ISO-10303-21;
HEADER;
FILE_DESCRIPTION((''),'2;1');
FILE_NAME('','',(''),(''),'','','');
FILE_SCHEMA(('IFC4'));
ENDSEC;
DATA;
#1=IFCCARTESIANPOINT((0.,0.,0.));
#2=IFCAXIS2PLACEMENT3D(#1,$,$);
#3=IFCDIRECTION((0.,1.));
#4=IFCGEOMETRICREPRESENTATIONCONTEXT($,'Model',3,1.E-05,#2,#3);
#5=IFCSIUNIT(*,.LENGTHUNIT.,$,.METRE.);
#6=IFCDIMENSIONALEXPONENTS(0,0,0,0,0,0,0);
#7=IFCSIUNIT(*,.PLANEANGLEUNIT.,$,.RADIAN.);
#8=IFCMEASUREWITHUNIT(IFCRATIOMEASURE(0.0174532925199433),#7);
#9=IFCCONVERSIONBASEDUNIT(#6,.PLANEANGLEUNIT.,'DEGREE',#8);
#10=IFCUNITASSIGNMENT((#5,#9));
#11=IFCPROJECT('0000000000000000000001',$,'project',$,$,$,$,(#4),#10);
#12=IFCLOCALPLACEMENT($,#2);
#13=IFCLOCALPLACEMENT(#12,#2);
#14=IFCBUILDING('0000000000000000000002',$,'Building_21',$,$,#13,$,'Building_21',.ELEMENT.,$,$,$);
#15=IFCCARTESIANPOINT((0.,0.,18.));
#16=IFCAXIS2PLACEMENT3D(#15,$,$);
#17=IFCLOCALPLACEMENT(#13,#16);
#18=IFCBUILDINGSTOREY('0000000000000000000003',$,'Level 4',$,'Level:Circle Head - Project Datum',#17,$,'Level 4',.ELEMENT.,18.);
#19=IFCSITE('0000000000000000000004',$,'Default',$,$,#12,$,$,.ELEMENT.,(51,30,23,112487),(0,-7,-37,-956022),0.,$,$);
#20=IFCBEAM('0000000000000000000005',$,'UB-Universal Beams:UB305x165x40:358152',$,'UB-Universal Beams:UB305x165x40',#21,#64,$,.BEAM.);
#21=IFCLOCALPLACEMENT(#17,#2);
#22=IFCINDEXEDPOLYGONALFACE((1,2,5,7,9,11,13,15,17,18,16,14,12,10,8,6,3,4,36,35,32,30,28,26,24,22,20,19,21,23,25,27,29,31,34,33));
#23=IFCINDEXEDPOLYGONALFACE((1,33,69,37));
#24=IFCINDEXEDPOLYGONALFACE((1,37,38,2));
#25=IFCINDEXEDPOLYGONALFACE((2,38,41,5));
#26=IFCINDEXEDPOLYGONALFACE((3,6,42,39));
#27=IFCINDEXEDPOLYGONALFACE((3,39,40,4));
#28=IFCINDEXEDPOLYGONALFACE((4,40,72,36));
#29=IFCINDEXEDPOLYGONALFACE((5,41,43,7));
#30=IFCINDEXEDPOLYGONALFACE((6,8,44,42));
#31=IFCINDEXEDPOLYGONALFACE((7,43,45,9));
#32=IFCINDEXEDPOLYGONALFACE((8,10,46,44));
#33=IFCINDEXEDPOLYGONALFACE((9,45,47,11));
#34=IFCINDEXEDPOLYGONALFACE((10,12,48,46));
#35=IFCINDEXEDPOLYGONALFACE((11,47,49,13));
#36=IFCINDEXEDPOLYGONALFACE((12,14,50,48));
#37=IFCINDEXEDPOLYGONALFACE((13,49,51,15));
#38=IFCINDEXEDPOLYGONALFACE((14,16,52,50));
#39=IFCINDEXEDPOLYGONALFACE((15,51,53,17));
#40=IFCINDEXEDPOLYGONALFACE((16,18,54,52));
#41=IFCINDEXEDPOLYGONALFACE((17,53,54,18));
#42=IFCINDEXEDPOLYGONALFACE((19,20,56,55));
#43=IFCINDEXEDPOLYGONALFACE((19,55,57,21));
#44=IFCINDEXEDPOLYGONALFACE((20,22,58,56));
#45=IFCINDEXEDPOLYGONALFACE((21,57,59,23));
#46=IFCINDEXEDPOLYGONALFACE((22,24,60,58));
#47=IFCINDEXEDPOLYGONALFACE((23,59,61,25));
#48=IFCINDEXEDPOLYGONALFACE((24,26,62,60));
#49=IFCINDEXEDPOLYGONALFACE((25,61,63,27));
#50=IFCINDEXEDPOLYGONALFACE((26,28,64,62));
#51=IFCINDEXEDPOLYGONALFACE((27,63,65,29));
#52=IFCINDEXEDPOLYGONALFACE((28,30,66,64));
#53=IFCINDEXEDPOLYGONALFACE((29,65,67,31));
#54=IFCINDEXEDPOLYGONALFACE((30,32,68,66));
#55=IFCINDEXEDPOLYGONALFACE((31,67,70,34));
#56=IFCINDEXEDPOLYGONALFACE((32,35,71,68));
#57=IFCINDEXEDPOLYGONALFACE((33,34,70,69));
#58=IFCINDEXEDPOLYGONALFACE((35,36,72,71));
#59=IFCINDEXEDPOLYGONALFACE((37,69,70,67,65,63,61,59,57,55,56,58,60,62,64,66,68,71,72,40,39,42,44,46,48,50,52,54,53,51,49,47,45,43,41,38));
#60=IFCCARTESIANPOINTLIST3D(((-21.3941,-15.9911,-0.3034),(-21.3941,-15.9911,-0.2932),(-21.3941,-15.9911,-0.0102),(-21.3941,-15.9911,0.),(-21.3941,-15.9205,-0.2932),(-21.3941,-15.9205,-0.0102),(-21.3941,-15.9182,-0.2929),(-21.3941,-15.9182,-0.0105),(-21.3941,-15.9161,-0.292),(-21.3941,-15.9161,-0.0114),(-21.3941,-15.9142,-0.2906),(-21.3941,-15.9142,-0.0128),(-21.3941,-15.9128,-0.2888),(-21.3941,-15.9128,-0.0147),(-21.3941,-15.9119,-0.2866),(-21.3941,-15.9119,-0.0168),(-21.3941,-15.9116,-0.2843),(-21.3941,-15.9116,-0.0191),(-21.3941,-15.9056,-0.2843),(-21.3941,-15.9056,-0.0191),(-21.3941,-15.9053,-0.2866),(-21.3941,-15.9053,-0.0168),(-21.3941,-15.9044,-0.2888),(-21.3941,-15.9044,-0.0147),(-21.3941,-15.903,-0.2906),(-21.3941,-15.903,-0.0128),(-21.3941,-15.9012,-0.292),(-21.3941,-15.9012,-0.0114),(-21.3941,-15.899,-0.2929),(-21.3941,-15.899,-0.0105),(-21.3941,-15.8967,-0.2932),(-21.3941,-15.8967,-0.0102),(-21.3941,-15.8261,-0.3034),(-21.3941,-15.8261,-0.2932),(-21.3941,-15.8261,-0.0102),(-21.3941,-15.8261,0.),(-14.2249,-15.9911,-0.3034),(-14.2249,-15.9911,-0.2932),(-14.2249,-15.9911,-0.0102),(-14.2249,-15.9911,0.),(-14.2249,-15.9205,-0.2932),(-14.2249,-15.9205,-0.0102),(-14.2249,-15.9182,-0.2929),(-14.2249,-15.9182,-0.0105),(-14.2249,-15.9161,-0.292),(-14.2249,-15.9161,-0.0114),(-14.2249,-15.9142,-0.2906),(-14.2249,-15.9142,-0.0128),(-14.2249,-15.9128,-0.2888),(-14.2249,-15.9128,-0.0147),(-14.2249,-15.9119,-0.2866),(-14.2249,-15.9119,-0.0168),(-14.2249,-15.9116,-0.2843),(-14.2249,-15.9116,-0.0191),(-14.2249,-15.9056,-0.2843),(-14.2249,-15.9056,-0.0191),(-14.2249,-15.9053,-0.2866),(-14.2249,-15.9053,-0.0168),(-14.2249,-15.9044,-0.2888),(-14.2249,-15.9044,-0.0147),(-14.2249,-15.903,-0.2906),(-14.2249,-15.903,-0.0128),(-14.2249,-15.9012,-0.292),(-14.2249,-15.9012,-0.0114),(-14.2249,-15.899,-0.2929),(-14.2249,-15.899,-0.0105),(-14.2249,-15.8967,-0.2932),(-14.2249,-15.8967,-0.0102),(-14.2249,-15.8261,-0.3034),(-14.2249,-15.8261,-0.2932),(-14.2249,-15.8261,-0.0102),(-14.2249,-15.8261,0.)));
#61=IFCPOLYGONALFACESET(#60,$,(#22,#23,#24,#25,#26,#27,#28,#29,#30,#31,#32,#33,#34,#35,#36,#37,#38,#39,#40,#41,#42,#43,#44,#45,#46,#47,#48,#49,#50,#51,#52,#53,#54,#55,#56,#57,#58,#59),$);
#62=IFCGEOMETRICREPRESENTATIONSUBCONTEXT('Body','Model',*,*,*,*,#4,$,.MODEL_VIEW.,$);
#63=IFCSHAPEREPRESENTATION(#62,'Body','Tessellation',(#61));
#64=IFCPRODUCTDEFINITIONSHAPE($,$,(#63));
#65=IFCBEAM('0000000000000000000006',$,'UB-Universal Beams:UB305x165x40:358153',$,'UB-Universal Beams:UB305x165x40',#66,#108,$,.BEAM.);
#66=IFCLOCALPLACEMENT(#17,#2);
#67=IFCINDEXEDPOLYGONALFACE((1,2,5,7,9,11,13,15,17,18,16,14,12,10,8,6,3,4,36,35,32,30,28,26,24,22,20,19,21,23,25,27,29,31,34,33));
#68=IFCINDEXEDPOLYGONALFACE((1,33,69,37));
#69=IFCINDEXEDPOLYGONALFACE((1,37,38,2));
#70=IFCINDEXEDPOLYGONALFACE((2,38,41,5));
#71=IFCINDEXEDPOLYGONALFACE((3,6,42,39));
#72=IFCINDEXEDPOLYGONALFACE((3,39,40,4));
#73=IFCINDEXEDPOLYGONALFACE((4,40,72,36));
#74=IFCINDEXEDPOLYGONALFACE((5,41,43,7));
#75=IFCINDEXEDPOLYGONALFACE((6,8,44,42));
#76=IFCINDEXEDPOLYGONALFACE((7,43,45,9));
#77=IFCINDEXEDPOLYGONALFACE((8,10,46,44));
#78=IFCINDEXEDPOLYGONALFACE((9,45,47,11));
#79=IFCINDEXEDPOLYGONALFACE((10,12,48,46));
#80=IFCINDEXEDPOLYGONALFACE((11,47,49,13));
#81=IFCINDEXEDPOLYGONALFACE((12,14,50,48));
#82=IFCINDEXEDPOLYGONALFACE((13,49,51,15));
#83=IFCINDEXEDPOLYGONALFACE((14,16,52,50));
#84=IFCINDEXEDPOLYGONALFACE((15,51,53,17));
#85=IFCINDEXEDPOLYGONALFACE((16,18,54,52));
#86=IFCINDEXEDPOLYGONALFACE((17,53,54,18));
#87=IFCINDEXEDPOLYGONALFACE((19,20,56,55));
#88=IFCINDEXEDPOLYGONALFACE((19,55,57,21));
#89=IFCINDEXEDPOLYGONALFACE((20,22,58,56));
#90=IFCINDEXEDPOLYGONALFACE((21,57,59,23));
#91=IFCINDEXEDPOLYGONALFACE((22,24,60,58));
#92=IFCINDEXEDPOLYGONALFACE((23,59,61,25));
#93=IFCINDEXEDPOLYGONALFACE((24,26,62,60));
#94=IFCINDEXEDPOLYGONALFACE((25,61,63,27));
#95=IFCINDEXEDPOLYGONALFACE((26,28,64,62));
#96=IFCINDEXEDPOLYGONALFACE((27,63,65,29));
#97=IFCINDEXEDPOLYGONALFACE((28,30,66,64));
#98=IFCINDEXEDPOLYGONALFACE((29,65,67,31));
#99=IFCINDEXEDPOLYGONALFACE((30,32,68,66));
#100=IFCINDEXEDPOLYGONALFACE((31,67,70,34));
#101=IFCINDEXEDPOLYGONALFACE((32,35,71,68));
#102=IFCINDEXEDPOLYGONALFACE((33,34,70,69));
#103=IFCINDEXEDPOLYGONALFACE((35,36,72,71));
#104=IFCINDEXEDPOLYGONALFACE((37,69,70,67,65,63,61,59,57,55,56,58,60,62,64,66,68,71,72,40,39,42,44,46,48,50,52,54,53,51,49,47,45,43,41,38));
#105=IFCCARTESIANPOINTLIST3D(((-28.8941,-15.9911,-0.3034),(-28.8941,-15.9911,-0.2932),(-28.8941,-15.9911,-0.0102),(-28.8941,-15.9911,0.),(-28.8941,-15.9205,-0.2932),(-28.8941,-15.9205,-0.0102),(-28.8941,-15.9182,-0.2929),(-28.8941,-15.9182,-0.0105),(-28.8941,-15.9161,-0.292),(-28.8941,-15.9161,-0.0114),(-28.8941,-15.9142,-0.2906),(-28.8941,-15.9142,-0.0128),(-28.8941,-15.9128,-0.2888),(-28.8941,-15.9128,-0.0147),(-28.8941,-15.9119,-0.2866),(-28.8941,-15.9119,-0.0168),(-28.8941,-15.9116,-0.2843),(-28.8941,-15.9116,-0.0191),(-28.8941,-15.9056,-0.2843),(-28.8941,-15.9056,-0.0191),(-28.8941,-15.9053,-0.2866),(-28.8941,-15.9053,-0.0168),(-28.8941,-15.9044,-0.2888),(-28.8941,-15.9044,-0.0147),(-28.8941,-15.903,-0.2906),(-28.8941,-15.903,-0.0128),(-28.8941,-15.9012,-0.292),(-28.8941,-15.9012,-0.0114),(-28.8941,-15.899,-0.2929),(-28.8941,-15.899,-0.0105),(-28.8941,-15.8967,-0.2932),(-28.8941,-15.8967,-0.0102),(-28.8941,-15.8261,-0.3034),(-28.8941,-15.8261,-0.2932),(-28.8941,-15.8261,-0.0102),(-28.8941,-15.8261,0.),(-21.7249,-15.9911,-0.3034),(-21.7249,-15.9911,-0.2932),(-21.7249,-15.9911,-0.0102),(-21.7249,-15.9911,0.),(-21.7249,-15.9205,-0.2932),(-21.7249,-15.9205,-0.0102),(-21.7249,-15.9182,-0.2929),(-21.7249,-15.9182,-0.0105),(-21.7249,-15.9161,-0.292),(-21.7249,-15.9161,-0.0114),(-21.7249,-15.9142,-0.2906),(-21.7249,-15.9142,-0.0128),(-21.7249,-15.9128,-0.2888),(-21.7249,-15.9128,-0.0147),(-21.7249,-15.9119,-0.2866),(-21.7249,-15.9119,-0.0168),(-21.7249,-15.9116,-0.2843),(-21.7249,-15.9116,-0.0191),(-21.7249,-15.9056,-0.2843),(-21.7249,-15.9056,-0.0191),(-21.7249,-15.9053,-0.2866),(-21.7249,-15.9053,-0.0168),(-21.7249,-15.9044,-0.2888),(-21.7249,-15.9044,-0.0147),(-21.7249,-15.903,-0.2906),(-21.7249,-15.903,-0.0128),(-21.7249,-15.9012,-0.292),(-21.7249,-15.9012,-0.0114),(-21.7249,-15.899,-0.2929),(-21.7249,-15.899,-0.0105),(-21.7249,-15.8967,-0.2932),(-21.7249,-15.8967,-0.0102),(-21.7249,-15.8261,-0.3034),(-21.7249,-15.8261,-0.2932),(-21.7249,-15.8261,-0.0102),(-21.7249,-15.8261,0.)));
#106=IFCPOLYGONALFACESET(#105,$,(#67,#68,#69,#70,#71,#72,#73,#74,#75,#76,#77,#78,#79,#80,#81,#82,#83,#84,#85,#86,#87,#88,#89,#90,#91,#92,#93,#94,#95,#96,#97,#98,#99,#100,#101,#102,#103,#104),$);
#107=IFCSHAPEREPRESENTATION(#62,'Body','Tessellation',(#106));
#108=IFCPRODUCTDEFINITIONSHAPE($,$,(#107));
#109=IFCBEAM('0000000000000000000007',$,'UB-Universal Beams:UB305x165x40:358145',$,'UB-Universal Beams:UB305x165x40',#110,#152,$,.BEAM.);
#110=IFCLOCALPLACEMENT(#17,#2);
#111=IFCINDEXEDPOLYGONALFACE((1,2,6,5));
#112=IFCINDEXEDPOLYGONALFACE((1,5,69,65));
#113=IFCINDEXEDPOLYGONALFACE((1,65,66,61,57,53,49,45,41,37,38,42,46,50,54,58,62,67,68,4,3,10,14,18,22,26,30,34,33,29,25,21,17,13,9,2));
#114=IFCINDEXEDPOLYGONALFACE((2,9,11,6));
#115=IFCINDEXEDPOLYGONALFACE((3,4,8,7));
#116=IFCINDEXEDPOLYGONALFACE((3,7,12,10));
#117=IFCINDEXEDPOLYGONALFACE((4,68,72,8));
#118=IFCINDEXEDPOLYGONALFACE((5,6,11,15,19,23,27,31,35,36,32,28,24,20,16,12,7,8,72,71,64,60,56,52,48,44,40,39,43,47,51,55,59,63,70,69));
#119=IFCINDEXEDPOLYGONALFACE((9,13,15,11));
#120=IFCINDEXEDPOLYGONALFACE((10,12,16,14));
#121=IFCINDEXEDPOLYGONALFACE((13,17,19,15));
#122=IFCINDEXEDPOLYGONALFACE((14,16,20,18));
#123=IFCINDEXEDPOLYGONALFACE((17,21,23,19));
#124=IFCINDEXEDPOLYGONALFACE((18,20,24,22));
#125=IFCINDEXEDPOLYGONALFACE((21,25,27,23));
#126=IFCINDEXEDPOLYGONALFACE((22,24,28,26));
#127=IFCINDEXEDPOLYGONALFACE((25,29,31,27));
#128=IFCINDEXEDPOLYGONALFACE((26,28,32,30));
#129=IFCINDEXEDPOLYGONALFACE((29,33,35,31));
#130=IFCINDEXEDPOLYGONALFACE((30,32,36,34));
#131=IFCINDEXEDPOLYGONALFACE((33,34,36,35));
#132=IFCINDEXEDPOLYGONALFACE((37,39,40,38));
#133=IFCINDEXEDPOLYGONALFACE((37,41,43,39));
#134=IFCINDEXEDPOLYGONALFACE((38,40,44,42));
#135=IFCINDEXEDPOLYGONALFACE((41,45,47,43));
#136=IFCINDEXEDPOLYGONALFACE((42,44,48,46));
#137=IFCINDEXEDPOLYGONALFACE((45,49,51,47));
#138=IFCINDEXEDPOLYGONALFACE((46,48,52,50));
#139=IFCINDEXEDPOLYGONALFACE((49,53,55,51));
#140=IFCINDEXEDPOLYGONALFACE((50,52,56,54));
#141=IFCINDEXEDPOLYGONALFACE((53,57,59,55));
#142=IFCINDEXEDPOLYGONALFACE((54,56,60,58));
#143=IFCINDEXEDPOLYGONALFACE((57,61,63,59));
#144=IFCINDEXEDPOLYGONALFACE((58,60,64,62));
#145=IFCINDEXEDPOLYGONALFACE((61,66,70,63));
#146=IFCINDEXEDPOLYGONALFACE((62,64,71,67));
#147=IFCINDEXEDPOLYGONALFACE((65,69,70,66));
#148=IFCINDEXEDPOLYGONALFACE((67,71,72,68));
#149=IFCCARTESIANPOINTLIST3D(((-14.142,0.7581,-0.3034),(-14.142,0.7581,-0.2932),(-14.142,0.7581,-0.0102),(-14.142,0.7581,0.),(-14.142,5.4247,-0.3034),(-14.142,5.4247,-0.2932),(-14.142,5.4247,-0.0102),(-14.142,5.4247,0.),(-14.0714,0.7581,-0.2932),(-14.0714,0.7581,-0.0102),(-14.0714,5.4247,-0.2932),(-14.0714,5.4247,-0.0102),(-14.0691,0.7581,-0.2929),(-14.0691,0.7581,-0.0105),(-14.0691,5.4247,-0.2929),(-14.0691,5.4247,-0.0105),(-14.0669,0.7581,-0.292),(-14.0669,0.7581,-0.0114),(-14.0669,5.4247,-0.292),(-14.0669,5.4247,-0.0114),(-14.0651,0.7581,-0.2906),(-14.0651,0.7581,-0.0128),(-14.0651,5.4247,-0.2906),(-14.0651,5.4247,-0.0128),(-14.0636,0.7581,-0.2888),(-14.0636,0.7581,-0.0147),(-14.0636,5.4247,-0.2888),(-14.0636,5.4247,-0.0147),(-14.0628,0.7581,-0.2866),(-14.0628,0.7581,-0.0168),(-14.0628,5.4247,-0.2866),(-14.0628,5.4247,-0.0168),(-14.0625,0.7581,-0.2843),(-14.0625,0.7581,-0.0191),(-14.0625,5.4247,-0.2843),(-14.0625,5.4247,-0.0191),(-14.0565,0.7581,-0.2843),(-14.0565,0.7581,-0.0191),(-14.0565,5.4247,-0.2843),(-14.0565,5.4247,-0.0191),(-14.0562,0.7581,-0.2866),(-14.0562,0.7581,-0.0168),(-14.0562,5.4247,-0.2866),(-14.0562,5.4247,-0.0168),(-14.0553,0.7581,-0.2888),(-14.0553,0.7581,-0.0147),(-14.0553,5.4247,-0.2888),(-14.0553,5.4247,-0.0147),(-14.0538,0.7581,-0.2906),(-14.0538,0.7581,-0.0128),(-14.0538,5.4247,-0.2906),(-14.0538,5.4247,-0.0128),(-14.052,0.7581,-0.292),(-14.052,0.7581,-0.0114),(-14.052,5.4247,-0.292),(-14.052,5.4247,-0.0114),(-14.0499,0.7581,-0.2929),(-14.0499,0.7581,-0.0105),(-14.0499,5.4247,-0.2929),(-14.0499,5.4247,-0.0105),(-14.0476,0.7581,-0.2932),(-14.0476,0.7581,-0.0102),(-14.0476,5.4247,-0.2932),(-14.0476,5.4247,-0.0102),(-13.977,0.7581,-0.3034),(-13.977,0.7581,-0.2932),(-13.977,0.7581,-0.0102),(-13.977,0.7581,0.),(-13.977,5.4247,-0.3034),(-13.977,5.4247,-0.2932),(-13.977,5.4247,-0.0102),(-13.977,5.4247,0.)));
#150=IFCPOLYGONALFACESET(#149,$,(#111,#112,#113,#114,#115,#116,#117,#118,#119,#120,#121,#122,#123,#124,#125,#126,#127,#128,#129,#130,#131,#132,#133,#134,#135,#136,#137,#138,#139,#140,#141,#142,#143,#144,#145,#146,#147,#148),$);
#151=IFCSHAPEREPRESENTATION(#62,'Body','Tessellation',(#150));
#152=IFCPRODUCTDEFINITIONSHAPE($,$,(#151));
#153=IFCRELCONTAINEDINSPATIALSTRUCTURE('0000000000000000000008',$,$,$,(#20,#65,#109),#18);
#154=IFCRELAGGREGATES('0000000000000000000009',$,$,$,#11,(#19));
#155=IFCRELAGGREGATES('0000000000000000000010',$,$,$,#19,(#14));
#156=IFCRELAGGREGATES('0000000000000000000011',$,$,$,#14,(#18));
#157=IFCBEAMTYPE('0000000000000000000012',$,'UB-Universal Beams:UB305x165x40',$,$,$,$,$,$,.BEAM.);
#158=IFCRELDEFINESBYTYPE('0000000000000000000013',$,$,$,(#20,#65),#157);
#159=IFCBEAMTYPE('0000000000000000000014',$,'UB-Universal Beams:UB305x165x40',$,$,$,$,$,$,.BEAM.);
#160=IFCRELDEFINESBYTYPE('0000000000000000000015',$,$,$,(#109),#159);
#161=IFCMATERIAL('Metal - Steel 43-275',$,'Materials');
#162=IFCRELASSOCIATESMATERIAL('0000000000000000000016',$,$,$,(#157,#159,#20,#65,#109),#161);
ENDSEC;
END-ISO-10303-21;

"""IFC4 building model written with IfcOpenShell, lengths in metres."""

from ifc_helpers import new_model, entity, si_unit, converted_unit, direction, frame, frame_2d, origin, place, context, subcontext, project, spatial, polyline, circle_curve, parameter, trimmed, segment, composite_curve, i_section, outline, extrude, source, transform, mapped, material, material_profile, profile_set, profile_usage, type_object, type_shapes, element, save


model = new_model("IFC4")

# Units and contexts
model_context = context("Model", 3, precision=1e-05, world=origin(), true_north=direction((0.0, 1.0)))
body_context = subcontext(model_context, "Body", "Model", "MODEL_VIEW")
ifc_project = project(units=[si_unit("LENGTHUNIT", "METRE"), converted_unit("PLANEANGLEUNIT", "DEGREE", entity("IfcRatioMeasure", 0.0174532925199433), si_unit("PLANEANGLEUNIT", "RADIAN"), dimensions=[0, 0, 0, 0, 0, 0, 0])], contexts=[model_context])

# Site, building, storey
site_placement = place(None, origin())
site = spatial("IfcSite", under=ifc_project, at=site_placement, Name="Default", CompositionType="ELEMENT", RefLatitude=(51, 30, 23, 112487), RefLongitude=(0, -7, -37, -956022), RefElevation=0.0)
building_placement = place(site_placement, origin())
building = spatial("IfcBuilding", under=site, at=building_placement, Name="Building_21", LongName="Building_21", CompositionType="ELEMENT")
storey_placement = place(building_placement, frame((0.0, 0.0, 18.0)))
storey = spatial("IfcBuildingStorey", under=building, at=storey_placement, Name="Level 4", ObjectType="Level:Circle Head - Project Datum", LongName="Level 4", CompositionType="ELEMENT", Elevation=18.0)

# Beams
ifc_material_1 = material(Name="Metal - Steel 43-275", Category="Materials")
ifc_material_profile_1 = material_profile(ifc_material_1, outline(composite_curve([segment(polyline([(0.0119, -0.1415, 0.0), (0.0825, -0.1415, 0.0)]), True, "CONTINUOUS"), segment(polyline([(0.0825, -0.1415, 0.0), (0.0825, -0.1517, 0.0)]), True, "CONTINUOUS"), segment(polyline([(0.0825, -0.1517, 0.0), (-0.0825, -0.1517, 0.0)]), True, "CONTINUOUS"), segment(polyline([(-0.0825, -0.1517, 0.0), (-0.0825, -0.1415, 0.0)]), True, "CONTINUOUS"), segment(polyline([(-0.0825, -0.1415, 0.0), (-0.0119, -0.1415, 0.0)]), True, "CONTINUOUS"), segment(trimmed(circle_curve(frame((-0.0119, -0.1326, 0.0), z_axis=(0.0, 0.0, 1.0), x_axis=(-1.0, 0.0, 0.0)), 0.0089), [parameter(90.0)], [parameter(180.0)], True, "PARAMETER"), True, "CONTINUOUS"), segment(polyline([(-0.003, -0.1326, 0.0), (-0.003, 0.1326, 0.0)]), True, "CONTINUOUS"), segment(trimmed(circle_curve(frame((-0.0119, 0.1326, 0.0), z_axis=(0.0, 0.0, 1.0), x_axis=(-1.0, 0.0, 0.0)), 0.0089), [parameter(180.0)], [parameter(270.0)], True, "PARAMETER"), True, "CONTINUOUS"), segment(polyline([(-0.0119, 0.1415, 0.0), (-0.0825, 0.1415, 0.0)]), True, "CONTINUOUS"), segment(polyline([(-0.0825, 0.1415, 0.0), (-0.0825, 0.1517, 0.0)]), True, "CONTINUOUS"), segment(polyline([(-0.0825, 0.1517, 0.0), (0.0825, 0.1517, 0.0)]), True, "CONTINUOUS"), segment(polyline([(0.0825, 0.1517, 0.0), (0.0825, 0.1415, 0.0)]), True, "CONTINUOUS"), segment(polyline([(0.0825, 0.1415, 0.0), (0.0119, 0.1415, 0.0)]), True, "CONTINUOUS"), segment(trimmed(circle_curve(frame((0.0119, 0.1326, 0.0), z_axis=(0.0, 0.0, 1.0), x_axis=(-1.0, 0.0, 0.0)), 0.0089), [parameter(270.0)], [parameter(0.0)], True, "PARAMETER"), True, "CONTINUOUS"), segment(polyline([(0.003, 0.1326, 0.0), (0.003, -0.1326, 0.0)]), True, "CONTINUOUS"), segment(trimmed(circle_curve(frame((0.0119, -0.1326, 0.0), z_axis=(0.0, 0.0, 1.0), x_axis=(-1.0, 0.0, 0.0)), 0.0089), [parameter(0.0)], [parameter(90.0)], True, "PARAMETER"), True, "CONTINUOUS")], self_intersect=False), kind="CURVE"), Name="UB305x165x40")
ifc_material_profile_2 = material_profile(ifc_material_1, outline(composite_curve([segment(polyline([(-1.3346, 0.0825, -0.1415), (-1.3346, 0.0825, -0.1517)]), True, "CONTINUOUS"), segment(polyline([(-1.3346, 0.0825, -0.1517), (-1.3346, -0.0825, -0.1517)]), True, "CONTINUOUS"), segment(polyline([(-1.3346, -0.0825, -0.1517), (-1.3346, -0.0825, -0.1415)]), True, "CONTINUOUS"), segment(polyline([(-1.3346, -0.0825, -0.1415), (-1.3346, -0.003, -0.1415)]), True, "CONTINUOUS"), segment(polyline([(-1.3346, -0.003, -0.1415), (-1.3346, -0.003, 0.1415)]), True, "CONTINUOUS"), segment(polyline([(-1.3346, -0.003, 0.1415), (-1.3346, -0.0825, 0.1415)]), True, "CONTINUOUS"), segment(polyline([(-1.3346, -0.0825, 0.1415), (-1.3346, -0.0825, 0.1517)]), True, "CONTINUOUS"), segment(polyline([(-1.3346, -0.0825, 0.1517), (-1.3346, 0.0825, 0.1517)]), True, "CONTINUOUS"), segment(polyline([(-1.3346, 0.0825, 0.1517), (-1.3346, 0.0825, 0.1415)]), True, "CONTINUOUS"), segment(polyline([(-1.3346, 0.0825, 0.1415), (-1.3346, 0.003, 0.1415)]), True, "CONTINUOUS"), segment(polyline([(-1.3346, 0.003, 0.1415), (-1.3346, 0.003, -0.1415)]), True, "CONTINUOUS"), segment(polyline([(-1.3346, 0.003, -0.1415), (-1.3346, 0.0825, -0.1415)]), True, "CONTINUOUS")], self_intersect=False), kind="CURVE"), Name="UB305x165x40")
ifc_profile_set = profile_set([ifc_material_profile_1, ifc_material_profile_2], Name="UB305x165x40")
beam_type_1 = type_object("IfcBeamType", Name="UB-Universal Beams:UB305x165x40", PredefinedType="BEAM", material=ifc_profile_set)
shared_shape_1 = source(origin(), body_context, "Body", "SweptSolid", [
    extrude(i_section(OverallWidth=0.165, OverallDepth=0.3034, WebThickness=0.006, FlangeThickness=0.0102, FilletRadius=0.0089, at=frame_2d((0.0, 0.0), x_axis=(0.0, 1.0))), frame((-3.5846, 0.0, 0.0), z_axis=(1.0, 0.0, 0.0), x_axis=(0.0, 0.0, -1.0)), (0.0, 0.0, 1.0), 7.1692),
])
type_shapes(beam_type_1, [shared_shape_1])
ifc_profile_usage_1 = profile_usage(ifc_profile_set, cardinal=8)
beam_1_placement = place(storey_placement, frame((-17.8095, -15.9086, -0.1517)))
element("IfcBeam", 1, at=beam_1_placement, inside=storey, type_object=beam_type_1, material=ifc_profile_usage_1, Name="UB-Universal Beams:UB305x165x40:358152", ObjectType="UB-Universal Beams:UB305x165x40", PredefinedType="BEAM", context=body_context, shape_type="MappedRepresentation", body=[
    mapped(shared_shape_1, transform((0.0, 0.0, 0.0), scale=1.0)),
])
ifc_profile_usage_2 = profile_usage(ifc_profile_set, cardinal=8)
beam_2_placement = place(storey_placement, frame((-25.3095, -15.9086, -0.1517)))
element("IfcBeam", 2, at=beam_2_placement, inside=storey, type_object=beam_type_1, material=ifc_profile_usage_2, Name="UB-Universal Beams:UB305x165x40:358153", ObjectType="UB-Universal Beams:UB305x165x40", PredefinedType="BEAM", context=body_context, shape_type="MappedRepresentation", body=[
    mapped(shared_shape_1, transform((0.0, 0.0, 0.0), scale=1.0)),
])
ifc_profile_usage_3 = profile_usage(ifc_profile_set, cardinal=8)
beam_type_2 = type_object("IfcBeamType", Name="UB-Universal Beams:UB305x165x40", PredefinedType="BEAM", material=ifc_profile_set)
shared_shape_2 = source(origin(), body_context, "Body", "SweptSolid", [
    extrude(i_section(OverallWidth=0.165, OverallDepth=0.3034, WebThickness=0.006, FlangeThickness=0.0102, FilletRadius=0.0089, at=frame_2d((0.0, 0.0), x_axis=(0.0, 1.0))), frame((-2.3333, 0.0, 0.0), z_axis=(1.0, 0.0, 0.0), x_axis=(0.0, 0.0, -1.0)), (0.0, 0.0, 1.0), 4.6666),
])
type_shapes(beam_type_2, [shared_shape_2])
beam_3_placement = place(storey_placement, frame((-14.0595, 3.0914, -0.1517), z_axis=(0.0, 0.0, 1.0), x_axis=(0.0, 1.0, 0.0)))
element("IfcBeam", 3, at=beam_3_placement, inside=storey, type_object=beam_type_2, material=ifc_profile_usage_3, Name="UB-Universal Beams:UB305x165x40:358145", ObjectType="UB-Universal Beams:UB305x165x40", PredefinedType="BEAM", context=body_context, shape_type="MappedRepresentation", body=[
    mapped(shared_shape_2, transform((0.0, 0.0, 0.0), scale=1.0)),
])

save(model, "model.ifc")
